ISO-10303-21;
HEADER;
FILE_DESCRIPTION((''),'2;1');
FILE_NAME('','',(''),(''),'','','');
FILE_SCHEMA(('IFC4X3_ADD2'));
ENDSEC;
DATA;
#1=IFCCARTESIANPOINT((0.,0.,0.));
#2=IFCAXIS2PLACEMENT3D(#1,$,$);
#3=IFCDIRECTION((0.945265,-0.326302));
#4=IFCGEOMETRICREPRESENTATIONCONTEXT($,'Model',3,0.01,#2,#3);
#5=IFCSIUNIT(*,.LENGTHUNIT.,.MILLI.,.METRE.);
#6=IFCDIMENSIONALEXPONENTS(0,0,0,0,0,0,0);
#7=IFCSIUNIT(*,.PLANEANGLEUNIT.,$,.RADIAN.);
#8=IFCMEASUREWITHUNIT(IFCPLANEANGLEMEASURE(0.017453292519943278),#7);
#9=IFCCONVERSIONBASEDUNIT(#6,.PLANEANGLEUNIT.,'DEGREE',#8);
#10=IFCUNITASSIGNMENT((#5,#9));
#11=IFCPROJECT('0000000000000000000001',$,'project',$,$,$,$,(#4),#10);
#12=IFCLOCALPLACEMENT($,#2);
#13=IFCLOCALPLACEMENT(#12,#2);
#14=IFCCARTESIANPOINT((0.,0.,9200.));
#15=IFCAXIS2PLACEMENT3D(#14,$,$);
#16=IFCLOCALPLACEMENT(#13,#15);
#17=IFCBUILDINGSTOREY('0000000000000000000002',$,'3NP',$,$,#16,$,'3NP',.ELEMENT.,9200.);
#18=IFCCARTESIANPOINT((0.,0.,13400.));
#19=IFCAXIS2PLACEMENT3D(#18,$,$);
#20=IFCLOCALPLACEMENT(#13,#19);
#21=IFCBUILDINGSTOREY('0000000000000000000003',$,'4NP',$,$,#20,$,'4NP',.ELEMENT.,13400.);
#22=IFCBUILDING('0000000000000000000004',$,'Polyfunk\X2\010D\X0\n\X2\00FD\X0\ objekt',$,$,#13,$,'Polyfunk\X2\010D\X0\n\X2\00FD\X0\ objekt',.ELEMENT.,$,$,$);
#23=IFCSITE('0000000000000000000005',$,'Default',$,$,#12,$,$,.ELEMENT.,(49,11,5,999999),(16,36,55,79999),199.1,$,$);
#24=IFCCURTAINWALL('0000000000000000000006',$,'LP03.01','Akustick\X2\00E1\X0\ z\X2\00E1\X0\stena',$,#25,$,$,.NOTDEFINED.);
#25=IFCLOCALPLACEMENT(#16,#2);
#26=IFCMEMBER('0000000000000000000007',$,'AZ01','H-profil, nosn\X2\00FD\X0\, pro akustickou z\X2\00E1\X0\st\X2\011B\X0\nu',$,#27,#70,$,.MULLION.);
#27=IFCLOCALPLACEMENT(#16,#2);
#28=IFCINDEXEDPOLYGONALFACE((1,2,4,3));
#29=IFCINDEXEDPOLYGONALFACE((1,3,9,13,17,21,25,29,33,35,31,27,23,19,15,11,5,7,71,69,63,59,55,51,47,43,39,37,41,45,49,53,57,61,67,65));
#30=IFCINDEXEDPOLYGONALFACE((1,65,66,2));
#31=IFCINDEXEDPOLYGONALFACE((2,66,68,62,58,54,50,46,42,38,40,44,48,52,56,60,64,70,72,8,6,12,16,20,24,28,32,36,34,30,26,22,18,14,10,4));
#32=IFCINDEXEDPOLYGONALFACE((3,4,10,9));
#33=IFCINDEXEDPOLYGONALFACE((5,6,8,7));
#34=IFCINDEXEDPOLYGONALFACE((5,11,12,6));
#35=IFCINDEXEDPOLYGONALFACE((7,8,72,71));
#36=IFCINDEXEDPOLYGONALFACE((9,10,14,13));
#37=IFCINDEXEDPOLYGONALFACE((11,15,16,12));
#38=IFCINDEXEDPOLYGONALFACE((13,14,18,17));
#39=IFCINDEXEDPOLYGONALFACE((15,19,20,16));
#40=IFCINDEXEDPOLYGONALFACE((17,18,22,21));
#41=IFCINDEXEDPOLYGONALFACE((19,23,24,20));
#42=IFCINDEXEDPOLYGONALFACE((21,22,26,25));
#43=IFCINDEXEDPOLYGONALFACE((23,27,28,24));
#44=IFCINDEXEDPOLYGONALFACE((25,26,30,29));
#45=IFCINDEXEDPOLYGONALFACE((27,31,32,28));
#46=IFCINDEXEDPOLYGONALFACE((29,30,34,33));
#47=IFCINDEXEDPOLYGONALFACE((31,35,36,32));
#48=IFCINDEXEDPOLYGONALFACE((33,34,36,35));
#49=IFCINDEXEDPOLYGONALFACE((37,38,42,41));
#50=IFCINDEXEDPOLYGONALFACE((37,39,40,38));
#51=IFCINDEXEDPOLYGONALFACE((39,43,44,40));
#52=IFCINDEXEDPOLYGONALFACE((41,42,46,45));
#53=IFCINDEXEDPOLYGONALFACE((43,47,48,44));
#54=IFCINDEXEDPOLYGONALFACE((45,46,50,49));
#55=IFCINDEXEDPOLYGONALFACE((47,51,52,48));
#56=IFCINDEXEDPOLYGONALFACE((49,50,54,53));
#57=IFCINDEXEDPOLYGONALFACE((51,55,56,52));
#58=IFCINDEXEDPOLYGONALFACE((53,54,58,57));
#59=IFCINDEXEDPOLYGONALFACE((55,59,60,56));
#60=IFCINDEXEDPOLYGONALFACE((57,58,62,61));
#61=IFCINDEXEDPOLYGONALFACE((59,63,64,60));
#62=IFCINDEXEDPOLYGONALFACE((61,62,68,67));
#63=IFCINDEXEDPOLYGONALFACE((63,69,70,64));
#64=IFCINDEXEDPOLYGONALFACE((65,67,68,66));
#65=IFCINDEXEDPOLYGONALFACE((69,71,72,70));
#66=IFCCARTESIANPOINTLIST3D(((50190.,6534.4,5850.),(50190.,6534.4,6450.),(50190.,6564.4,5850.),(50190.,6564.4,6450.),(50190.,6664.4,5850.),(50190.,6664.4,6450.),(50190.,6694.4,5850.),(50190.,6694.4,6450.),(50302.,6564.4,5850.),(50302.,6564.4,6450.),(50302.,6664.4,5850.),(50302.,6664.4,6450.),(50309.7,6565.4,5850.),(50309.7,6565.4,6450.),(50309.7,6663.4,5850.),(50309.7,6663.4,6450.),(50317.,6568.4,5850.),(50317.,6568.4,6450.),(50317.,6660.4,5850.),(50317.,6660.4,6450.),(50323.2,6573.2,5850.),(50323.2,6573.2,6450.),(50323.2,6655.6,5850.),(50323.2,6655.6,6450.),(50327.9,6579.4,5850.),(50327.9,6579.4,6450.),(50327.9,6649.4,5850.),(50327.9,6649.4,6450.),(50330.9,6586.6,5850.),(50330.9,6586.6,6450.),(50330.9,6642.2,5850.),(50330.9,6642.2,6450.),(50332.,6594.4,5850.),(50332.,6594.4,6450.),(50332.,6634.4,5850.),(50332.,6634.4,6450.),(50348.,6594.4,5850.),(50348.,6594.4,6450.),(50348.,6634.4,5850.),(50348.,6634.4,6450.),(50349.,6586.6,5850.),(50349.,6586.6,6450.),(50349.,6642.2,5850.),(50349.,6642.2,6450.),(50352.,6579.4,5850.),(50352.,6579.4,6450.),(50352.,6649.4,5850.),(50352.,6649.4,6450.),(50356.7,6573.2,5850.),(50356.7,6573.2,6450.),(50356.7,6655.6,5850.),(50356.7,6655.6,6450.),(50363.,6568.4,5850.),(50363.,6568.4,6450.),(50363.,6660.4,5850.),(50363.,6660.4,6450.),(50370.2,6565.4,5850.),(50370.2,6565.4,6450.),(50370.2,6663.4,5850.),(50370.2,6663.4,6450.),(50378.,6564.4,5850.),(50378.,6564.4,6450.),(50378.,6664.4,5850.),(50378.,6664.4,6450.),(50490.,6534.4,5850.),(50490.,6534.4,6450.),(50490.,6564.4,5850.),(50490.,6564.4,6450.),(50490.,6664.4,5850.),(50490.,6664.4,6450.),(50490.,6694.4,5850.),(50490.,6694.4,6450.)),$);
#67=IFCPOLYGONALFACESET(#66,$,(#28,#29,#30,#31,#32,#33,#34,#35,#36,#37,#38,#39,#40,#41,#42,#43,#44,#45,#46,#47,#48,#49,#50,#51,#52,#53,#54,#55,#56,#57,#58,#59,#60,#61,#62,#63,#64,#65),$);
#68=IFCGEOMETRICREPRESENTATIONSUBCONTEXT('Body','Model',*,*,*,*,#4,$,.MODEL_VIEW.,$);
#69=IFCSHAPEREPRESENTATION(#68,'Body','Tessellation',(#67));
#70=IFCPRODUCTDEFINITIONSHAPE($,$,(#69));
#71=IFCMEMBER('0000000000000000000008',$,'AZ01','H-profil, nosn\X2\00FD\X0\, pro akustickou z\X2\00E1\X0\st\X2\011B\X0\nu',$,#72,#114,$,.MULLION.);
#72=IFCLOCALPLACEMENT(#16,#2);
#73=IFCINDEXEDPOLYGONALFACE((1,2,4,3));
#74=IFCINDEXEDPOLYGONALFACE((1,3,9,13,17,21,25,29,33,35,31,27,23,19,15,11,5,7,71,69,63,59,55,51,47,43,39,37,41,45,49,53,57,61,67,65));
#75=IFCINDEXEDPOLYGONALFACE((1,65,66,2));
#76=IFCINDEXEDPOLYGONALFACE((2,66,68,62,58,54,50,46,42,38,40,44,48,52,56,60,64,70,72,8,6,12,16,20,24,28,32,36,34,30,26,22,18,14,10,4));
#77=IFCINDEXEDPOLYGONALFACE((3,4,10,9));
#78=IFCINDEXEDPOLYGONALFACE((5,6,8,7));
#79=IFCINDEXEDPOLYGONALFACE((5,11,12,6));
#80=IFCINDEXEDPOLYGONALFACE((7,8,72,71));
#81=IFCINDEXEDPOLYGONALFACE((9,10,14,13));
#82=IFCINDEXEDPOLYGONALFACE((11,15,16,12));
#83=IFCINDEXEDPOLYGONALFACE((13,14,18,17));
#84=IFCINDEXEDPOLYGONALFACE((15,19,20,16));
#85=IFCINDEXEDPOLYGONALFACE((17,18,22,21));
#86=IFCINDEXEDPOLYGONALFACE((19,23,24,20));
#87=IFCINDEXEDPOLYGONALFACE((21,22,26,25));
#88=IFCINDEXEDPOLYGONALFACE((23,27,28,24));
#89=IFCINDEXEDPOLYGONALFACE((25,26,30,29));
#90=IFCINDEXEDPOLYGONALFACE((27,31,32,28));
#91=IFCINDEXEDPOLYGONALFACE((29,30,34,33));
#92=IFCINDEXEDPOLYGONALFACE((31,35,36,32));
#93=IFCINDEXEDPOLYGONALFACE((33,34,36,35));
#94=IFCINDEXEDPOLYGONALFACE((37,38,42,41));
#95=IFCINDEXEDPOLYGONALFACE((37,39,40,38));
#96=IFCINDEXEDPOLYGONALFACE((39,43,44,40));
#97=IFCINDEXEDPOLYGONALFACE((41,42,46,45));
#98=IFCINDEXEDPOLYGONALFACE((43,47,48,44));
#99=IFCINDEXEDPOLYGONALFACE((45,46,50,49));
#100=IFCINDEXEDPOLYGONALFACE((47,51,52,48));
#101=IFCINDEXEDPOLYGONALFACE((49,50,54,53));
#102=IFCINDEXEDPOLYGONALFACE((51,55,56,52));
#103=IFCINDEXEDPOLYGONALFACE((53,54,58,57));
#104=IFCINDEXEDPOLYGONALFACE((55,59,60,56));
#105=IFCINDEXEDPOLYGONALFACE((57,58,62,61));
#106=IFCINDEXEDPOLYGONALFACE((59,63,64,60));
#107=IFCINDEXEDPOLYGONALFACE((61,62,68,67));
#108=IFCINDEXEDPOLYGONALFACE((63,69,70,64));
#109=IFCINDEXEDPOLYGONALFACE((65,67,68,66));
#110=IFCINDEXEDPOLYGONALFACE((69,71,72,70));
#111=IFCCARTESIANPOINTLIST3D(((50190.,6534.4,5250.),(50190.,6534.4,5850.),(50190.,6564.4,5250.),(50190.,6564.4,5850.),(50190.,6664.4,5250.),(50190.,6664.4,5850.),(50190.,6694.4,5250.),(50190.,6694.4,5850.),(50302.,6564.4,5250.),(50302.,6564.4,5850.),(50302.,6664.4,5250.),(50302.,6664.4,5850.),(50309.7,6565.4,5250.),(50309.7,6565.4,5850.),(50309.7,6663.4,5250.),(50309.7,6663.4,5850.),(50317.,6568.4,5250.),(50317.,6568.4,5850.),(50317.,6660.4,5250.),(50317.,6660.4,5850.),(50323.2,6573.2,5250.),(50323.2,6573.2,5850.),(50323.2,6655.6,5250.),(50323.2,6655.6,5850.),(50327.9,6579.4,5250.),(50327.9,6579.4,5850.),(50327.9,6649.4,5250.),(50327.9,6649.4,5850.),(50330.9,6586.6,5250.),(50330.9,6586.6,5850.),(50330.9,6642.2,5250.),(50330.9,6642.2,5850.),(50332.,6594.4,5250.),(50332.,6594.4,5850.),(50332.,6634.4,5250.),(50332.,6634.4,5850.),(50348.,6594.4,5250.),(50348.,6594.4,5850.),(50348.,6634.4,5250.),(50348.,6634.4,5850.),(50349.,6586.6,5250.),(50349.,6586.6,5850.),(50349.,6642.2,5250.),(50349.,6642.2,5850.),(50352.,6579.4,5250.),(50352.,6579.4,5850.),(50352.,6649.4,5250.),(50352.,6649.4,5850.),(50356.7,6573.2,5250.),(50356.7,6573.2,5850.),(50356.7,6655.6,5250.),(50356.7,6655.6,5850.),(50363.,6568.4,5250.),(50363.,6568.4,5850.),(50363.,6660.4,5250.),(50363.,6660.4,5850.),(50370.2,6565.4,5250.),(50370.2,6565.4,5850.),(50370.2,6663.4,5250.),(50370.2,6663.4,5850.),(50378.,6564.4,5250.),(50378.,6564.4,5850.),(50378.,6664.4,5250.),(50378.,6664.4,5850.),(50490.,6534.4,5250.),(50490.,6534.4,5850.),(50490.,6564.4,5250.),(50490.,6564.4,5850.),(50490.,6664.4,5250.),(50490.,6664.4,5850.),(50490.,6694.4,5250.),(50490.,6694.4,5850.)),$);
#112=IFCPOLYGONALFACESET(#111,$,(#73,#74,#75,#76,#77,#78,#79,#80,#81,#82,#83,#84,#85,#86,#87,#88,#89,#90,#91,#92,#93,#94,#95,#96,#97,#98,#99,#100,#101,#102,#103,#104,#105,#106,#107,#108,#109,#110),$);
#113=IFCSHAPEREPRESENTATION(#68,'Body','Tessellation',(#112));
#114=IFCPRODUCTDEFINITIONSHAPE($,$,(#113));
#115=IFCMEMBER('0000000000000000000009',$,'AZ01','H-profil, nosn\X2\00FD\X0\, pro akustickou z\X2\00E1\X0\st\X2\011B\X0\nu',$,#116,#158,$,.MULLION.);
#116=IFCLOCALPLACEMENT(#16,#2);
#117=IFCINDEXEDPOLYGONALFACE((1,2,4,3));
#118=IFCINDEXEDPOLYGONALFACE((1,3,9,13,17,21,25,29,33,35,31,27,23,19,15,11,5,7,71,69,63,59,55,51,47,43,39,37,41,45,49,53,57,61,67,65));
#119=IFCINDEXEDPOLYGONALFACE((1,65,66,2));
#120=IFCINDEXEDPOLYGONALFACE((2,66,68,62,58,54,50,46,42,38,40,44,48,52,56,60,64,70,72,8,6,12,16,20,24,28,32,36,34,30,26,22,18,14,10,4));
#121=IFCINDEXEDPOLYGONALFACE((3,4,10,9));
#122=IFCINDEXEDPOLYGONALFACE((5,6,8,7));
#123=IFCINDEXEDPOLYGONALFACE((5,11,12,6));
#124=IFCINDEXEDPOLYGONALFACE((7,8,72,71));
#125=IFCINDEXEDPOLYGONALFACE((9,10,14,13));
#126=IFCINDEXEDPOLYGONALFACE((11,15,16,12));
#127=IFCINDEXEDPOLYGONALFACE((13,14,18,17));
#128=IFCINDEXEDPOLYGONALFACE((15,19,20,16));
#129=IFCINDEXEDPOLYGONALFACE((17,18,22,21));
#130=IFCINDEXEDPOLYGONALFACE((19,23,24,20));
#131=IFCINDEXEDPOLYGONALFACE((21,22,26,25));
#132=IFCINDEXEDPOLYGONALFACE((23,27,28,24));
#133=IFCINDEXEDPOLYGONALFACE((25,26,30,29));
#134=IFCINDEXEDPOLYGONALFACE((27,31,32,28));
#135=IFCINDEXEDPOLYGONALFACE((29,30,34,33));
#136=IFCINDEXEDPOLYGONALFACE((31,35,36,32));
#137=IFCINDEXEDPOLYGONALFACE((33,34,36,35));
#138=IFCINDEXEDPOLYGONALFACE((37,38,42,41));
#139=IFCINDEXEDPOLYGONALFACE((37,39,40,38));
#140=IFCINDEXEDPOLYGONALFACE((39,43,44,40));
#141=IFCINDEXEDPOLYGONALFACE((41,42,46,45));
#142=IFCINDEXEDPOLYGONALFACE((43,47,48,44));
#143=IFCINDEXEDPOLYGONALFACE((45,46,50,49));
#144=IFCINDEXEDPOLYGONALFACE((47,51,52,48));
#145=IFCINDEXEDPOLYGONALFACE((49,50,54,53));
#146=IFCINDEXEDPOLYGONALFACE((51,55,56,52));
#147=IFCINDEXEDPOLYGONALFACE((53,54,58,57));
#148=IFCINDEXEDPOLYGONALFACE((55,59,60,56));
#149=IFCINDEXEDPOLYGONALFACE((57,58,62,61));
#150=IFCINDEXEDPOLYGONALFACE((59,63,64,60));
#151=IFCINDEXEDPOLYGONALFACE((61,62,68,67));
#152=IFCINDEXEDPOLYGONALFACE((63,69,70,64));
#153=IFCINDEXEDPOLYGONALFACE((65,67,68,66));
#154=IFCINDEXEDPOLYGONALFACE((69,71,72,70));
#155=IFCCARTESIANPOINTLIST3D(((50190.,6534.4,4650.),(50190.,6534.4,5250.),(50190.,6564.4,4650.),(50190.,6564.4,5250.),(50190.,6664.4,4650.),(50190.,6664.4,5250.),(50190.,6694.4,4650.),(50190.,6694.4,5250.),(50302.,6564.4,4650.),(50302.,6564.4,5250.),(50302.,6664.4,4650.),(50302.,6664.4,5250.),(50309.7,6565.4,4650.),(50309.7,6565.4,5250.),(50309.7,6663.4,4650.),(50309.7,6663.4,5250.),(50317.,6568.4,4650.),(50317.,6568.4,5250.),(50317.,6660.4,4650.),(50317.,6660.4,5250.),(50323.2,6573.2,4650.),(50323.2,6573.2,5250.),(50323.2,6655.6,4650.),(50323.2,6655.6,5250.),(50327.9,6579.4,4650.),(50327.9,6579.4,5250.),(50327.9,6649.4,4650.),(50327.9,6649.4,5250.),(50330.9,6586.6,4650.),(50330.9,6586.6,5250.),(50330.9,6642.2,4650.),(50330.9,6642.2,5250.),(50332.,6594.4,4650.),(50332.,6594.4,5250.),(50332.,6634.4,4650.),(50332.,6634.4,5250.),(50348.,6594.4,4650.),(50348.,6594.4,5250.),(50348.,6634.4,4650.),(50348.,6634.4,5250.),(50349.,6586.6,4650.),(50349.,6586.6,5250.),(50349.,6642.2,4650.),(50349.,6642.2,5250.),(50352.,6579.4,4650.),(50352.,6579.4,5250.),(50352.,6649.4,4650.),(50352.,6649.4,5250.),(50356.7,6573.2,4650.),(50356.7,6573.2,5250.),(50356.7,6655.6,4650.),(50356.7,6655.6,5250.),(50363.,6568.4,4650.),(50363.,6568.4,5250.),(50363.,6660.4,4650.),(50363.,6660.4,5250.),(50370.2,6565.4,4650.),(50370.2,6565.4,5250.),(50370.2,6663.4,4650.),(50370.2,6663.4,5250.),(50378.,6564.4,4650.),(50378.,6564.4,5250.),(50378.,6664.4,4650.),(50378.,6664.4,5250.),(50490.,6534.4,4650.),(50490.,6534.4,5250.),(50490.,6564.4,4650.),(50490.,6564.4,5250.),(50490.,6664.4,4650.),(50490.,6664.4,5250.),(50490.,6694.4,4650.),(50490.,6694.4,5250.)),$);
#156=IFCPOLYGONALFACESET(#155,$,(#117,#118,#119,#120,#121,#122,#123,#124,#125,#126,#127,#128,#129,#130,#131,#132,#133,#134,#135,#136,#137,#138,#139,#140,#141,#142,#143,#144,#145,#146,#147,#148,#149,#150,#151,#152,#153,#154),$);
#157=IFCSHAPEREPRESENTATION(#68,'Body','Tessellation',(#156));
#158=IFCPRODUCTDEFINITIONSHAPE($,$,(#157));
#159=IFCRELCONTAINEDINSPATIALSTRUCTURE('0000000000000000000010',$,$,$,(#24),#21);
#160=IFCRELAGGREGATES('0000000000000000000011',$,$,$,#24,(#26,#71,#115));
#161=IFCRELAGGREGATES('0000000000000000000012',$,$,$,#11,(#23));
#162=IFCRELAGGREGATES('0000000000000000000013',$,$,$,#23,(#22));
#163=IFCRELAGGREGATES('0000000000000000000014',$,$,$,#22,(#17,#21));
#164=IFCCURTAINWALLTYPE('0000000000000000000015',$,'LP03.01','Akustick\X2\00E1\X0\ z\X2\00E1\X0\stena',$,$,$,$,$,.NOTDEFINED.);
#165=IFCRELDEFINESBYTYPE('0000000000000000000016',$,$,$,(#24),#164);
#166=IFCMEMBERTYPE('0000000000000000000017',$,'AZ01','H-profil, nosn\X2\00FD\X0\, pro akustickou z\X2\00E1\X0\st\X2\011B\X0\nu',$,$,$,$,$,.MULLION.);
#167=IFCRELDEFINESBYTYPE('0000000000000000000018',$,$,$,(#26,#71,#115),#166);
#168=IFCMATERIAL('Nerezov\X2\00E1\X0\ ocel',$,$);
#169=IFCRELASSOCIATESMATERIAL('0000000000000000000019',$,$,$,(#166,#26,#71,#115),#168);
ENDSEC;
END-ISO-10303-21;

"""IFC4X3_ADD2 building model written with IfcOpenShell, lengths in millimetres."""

from ifc_helpers import new_model, entity, si_unit, converted_unit, direction, frame, frame_2d, origin, place, context, subcontext, project, spatial, polyline, circle_curve, parameter, trimmed, segment, composite_curve, outline, extrude, source, transform, mapped, material, material_profile, profile_set, profile_usage, type_object, element, aggregate, save


model = new_model("IFC4X3_ADD2")

# Units and contexts
model_context = context("Model", 3, precision=0.01, world=origin(), true_north=direction((0.945265, -0.326302)))
body_context = subcontext(model_context, "Body", "Model", "MODEL_VIEW")
ifc_project = project(units=[si_unit("LENGTHUNIT", "METRE", prefix="MILLI"), converted_unit("PLANEANGLEUNIT", "DEGREE", entity("IfcPlaneAngleMeasure", 0.017453292519943278), si_unit("PLANEANGLEUNIT", "RADIAN"), dimensions=[0, 0, 0, 0, 0, 0, 0])], contexts=[model_context])

# Site, building, storey
site_placement = place(None, origin())
site = spatial("IfcSite", under=ifc_project, at=site_placement, Name="Default", CompositionType="ELEMENT", RefLatitude=(49, 11, 5, 999999), RefLongitude=(16, 36, 55, 79999), RefElevation=199.1)
building_placement = place(site_placement, origin())
building = spatial("IfcBuilding", under=site, at=building_placement, Name="Polyfunkčný objekt", LongName="Polyfunkčný objekt", CompositionType="ELEMENT")
storey_1_placement = place(building_placement, frame((0.0, 0.0, 9200.0)))
storey_1 = spatial("IfcBuildingStorey", under=building, at=storey_1_placement, Name="3NP", LongName="3NP", CompositionType="ELEMENT", Elevation=9200.0)

# Shared definitions
storey_2_placement = place(building_placement, frame((0.0, 0.0, 13400.0)))
storey_2 = spatial("IfcBuildingStorey", under=building, at=storey_2_placement, Name="4NP", LongName="4NP", CompositionType="ELEMENT", Elevation=13400.0)

# Curtain wall, members
curtain_wall_type_1 = type_object("IfcCurtainWallType", Name="LP03.01", Description="Akustická zástena", PredefinedType="NOTDEFINED")
curtain_wall_1_placement = place(storey_2_placement, frame((0.0, 0.0, -13400.0)))
curtain_wall_1 = element("IfcCurtainWall", 1, at=curtain_wall_1_placement, inside=storey_2, type_object=curtain_wall_type_1, Name="LP03.01", Description="Akustická zástena", PredefinedType="NOTDEFINED")
ifc_material_1 = material(Name="Nerezová ocel")
ifc_material_profile_1 = material_profile(ifc_material_1, outline(composite_curve([segment(polyline([(50.0, -150.0), (80.0, -150.0)]), True, "CONTINUOUS"), segment(polyline([(80.0, -150.0), (80.0, 150.0)]), True, "CONTINUOUS"), segment(polyline([(80.0, 150.0), (50.0, 150.0)]), True, "CONTINUOUS"), segment(polyline([(50.0, 150.0), (50.0, 38.0)]), True, "CONTINUOUS"), segment(trimmed(circle_curve(frame_2d((20.0, 38.0), x_axis=(0.0, 1.0)), 30.0), [parameter(180.0)], [parameter(270.0)], True, "PARAMETER"), False, "CONTINUOUS"), segment(polyline([(20.0, 8.0), (-20.0, 8.0)]), True, "CONTINUOUS"), segment(trimmed(circle_curve(frame_2d((-20.0, 38.0), x_axis=(0.0, 1.0)), 30.0), [parameter(90.0)], [parameter(180.0)], True, "PARAMETER"), False, "CONTINUOUS"), segment(polyline([(-50.0, 38.0), (-50.0, 150.0)]), True, "CONTINUOUS"), segment(polyline([(-50.0, 150.0), (-80.0, 150.0)]), True, "CONTINUOUS"), segment(polyline([(-80.0, 150.0), (-80.0, -150.0)]), True, "CONTINUOUS"), segment(polyline([(-80.0, -150.0), (-50.0, -150.0)]), True, "CONTINUOUS"), segment(polyline([(-50.0, -150.0), (-50.0, -38.0)]), True, "CONTINUOUS"), segment(trimmed(circle_curve(frame_2d((-20.0, -38.0), x_axis=(0.0, 1.0)), 30.0), [parameter(0.0)], [parameter(90.0)], True, "PARAMETER"), False, "CONTINUOUS"), segment(polyline([(-20.0, -8.0), (20.0, -8.0)]), True, "CONTINUOUS"), segment(trimmed(circle_curve(frame_2d((20.0, -38.0), x_axis=(0.0, 1.0)), 30.0), [parameter(270.0)], [parameter(0.0)], True, "PARAMETER"), False, "CONTINUOUS"), segment(polyline([(50.0, -38.0), (50.0, -150.0)]), True, "CONTINUOUS")], self_intersect=False)), Name="Profil zástena")
ifc_profile_set_1 = profile_set([ifc_material_profile_1], Name="Profil zástena")
ifc_profile_usage_1 = profile_usage(ifc_profile_set_1)
member_type_1 = type_object("IfcMemberType", Name="AZ01", Description="H-profil, nosný, pro akustickou zástěnu", PredefinedType="MULLION", material=ifc_profile_set_1)
shared_shape_1 = source(origin(), body_context, "Body", "SweptSolid", [
    extrude(outline(composite_curve([segment(polyline([(-150.0, -50.0), (-150.0, -80.0)]), True, "CONTINUOUS"), segment(polyline([(-150.0, -80.0), (150.0, -80.0)]), True, "CONTINUOUS"), segment(polyline([(150.0, -80.0), (150.0, -50.0)]), True, "CONTINUOUS"), segment(polyline([(150.0, -50.0), (38.0, -50.0)]), True, "CONTINUOUS"), segment(trimmed(circle_curve(frame_2d((38.0, -20.0), x_axis=(1.0, 0.0)), 30.0), [parameter(180.0)], [parameter(270.0)], True, "PARAMETER"), False, "CONTINUOUS"), segment(polyline([(8.0, -20.0), (8.0, 20.0)]), True, "CONTINUOUS"), segment(trimmed(circle_curve(frame_2d((38.0, 20.0), x_axis=(1.0, 0.0)), 30.0), [parameter(90.0)], [parameter(180.0)], True, "PARAMETER"), False, "CONTINUOUS"), segment(polyline([(38.0, 50.0), (150.0, 50.0)]), True, "CONTINUOUS"), segment(polyline([(150.0, 50.0), (150.0, 80.0)]), True, "CONTINUOUS"), segment(polyline([(150.0, 80.0), (-150.0, 80.0)]), True, "CONTINUOUS"), segment(polyline([(-150.0, 80.0), (-150.0, 50.0)]), True, "CONTINUOUS"), segment(polyline([(-150.0, 50.0), (-38.0, 50.0)]), True, "CONTINUOUS"), segment(trimmed(circle_curve(frame_2d((-38.0, 20.0), x_axis=(1.0, 0.0)), 30.0), [parameter(0.0)], [parameter(90.0)], True, "PARAMETER"), False, "CONTINUOUS"), segment(polyline([(-8.0, 20.0), (-8.0, -20.0)]), True, "CONTINUOUS"), segment(trimmed(circle_curve(frame_2d((-38.0, -20.0), x_axis=(1.0, 0.0)), 30.0), [parameter(270.0)], [parameter(0.0)], True, "PARAMETER"), False, "CONTINUOUS"), segment(polyline([(-38.0, -50.0), (-150.0, -50.0)]), True, "CONTINUOUS")], self_intersect=False)), frame((-150.0, 0.0, -600.0), z_axis=(0.0, 0.0, -1.0), x_axis=(-1.0, 0.0, 0.0)), (0.0, 0.0, -1.0), 600.0),
])
member_1_placement = place(curtain_wall_1_placement, frame((50190.0, 6614.4, 15650.0), z_axis=(0.0, 0.0, 1.0), x_axis=(-1.0, 0.0, 0.0)))
member_1 = element("IfcMember", 2, at=member_1_placement, type_object=member_type_1, material=ifc_profile_usage_1, Name="AZ01", Description="H-profil, nosný, pro akustickou zástěnu", PredefinedType="MULLION", context=body_context, shape_type="MappedRepresentation", body=[
    mapped(shared_shape_1, transform((0.0, 0.0, 0.0), scale=1.0)),
])
member_2_placement = place(curtain_wall_1_placement, frame((50190.0, 6614.4, 15050.0), z_axis=(0.0, 0.0, 1.0), x_axis=(-1.0, 0.0, 0.0)))
member_2 = element("IfcMember", 3, at=member_2_placement, type_object=member_type_1, material=ifc_profile_usage_1, Name="AZ01", Description="H-profil, nosný, pro akustickou zástěnu", PredefinedType="MULLION", context=body_context, shape_type="MappedRepresentation", body=[
    mapped(shared_shape_1, transform((0.0, 0.0, 0.0), scale=1.0)),
])
member_3_placement = place(curtain_wall_1_placement, frame((50190.0, 6614.4, 14450.0), z_axis=(0.0, 0.0, 1.0), x_axis=(-1.0, 0.0, 0.0)))
member_3 = element("IfcMember", 4, at=member_3_placement, type_object=member_type_1, material=ifc_profile_usage_1, Name="AZ01", Description="H-profil, nosný, pro akustickou zástěnu", PredefinedType="MULLION", context=body_context, shape_type="MappedRepresentation", body=[
    mapped(shared_shape_1, transform((0.0, 0.0, 0.0), scale=1.0)),
])

aggregate(curtain_wall_1, [member_1, member_2, member_3])

save(model, "model.ifc")
